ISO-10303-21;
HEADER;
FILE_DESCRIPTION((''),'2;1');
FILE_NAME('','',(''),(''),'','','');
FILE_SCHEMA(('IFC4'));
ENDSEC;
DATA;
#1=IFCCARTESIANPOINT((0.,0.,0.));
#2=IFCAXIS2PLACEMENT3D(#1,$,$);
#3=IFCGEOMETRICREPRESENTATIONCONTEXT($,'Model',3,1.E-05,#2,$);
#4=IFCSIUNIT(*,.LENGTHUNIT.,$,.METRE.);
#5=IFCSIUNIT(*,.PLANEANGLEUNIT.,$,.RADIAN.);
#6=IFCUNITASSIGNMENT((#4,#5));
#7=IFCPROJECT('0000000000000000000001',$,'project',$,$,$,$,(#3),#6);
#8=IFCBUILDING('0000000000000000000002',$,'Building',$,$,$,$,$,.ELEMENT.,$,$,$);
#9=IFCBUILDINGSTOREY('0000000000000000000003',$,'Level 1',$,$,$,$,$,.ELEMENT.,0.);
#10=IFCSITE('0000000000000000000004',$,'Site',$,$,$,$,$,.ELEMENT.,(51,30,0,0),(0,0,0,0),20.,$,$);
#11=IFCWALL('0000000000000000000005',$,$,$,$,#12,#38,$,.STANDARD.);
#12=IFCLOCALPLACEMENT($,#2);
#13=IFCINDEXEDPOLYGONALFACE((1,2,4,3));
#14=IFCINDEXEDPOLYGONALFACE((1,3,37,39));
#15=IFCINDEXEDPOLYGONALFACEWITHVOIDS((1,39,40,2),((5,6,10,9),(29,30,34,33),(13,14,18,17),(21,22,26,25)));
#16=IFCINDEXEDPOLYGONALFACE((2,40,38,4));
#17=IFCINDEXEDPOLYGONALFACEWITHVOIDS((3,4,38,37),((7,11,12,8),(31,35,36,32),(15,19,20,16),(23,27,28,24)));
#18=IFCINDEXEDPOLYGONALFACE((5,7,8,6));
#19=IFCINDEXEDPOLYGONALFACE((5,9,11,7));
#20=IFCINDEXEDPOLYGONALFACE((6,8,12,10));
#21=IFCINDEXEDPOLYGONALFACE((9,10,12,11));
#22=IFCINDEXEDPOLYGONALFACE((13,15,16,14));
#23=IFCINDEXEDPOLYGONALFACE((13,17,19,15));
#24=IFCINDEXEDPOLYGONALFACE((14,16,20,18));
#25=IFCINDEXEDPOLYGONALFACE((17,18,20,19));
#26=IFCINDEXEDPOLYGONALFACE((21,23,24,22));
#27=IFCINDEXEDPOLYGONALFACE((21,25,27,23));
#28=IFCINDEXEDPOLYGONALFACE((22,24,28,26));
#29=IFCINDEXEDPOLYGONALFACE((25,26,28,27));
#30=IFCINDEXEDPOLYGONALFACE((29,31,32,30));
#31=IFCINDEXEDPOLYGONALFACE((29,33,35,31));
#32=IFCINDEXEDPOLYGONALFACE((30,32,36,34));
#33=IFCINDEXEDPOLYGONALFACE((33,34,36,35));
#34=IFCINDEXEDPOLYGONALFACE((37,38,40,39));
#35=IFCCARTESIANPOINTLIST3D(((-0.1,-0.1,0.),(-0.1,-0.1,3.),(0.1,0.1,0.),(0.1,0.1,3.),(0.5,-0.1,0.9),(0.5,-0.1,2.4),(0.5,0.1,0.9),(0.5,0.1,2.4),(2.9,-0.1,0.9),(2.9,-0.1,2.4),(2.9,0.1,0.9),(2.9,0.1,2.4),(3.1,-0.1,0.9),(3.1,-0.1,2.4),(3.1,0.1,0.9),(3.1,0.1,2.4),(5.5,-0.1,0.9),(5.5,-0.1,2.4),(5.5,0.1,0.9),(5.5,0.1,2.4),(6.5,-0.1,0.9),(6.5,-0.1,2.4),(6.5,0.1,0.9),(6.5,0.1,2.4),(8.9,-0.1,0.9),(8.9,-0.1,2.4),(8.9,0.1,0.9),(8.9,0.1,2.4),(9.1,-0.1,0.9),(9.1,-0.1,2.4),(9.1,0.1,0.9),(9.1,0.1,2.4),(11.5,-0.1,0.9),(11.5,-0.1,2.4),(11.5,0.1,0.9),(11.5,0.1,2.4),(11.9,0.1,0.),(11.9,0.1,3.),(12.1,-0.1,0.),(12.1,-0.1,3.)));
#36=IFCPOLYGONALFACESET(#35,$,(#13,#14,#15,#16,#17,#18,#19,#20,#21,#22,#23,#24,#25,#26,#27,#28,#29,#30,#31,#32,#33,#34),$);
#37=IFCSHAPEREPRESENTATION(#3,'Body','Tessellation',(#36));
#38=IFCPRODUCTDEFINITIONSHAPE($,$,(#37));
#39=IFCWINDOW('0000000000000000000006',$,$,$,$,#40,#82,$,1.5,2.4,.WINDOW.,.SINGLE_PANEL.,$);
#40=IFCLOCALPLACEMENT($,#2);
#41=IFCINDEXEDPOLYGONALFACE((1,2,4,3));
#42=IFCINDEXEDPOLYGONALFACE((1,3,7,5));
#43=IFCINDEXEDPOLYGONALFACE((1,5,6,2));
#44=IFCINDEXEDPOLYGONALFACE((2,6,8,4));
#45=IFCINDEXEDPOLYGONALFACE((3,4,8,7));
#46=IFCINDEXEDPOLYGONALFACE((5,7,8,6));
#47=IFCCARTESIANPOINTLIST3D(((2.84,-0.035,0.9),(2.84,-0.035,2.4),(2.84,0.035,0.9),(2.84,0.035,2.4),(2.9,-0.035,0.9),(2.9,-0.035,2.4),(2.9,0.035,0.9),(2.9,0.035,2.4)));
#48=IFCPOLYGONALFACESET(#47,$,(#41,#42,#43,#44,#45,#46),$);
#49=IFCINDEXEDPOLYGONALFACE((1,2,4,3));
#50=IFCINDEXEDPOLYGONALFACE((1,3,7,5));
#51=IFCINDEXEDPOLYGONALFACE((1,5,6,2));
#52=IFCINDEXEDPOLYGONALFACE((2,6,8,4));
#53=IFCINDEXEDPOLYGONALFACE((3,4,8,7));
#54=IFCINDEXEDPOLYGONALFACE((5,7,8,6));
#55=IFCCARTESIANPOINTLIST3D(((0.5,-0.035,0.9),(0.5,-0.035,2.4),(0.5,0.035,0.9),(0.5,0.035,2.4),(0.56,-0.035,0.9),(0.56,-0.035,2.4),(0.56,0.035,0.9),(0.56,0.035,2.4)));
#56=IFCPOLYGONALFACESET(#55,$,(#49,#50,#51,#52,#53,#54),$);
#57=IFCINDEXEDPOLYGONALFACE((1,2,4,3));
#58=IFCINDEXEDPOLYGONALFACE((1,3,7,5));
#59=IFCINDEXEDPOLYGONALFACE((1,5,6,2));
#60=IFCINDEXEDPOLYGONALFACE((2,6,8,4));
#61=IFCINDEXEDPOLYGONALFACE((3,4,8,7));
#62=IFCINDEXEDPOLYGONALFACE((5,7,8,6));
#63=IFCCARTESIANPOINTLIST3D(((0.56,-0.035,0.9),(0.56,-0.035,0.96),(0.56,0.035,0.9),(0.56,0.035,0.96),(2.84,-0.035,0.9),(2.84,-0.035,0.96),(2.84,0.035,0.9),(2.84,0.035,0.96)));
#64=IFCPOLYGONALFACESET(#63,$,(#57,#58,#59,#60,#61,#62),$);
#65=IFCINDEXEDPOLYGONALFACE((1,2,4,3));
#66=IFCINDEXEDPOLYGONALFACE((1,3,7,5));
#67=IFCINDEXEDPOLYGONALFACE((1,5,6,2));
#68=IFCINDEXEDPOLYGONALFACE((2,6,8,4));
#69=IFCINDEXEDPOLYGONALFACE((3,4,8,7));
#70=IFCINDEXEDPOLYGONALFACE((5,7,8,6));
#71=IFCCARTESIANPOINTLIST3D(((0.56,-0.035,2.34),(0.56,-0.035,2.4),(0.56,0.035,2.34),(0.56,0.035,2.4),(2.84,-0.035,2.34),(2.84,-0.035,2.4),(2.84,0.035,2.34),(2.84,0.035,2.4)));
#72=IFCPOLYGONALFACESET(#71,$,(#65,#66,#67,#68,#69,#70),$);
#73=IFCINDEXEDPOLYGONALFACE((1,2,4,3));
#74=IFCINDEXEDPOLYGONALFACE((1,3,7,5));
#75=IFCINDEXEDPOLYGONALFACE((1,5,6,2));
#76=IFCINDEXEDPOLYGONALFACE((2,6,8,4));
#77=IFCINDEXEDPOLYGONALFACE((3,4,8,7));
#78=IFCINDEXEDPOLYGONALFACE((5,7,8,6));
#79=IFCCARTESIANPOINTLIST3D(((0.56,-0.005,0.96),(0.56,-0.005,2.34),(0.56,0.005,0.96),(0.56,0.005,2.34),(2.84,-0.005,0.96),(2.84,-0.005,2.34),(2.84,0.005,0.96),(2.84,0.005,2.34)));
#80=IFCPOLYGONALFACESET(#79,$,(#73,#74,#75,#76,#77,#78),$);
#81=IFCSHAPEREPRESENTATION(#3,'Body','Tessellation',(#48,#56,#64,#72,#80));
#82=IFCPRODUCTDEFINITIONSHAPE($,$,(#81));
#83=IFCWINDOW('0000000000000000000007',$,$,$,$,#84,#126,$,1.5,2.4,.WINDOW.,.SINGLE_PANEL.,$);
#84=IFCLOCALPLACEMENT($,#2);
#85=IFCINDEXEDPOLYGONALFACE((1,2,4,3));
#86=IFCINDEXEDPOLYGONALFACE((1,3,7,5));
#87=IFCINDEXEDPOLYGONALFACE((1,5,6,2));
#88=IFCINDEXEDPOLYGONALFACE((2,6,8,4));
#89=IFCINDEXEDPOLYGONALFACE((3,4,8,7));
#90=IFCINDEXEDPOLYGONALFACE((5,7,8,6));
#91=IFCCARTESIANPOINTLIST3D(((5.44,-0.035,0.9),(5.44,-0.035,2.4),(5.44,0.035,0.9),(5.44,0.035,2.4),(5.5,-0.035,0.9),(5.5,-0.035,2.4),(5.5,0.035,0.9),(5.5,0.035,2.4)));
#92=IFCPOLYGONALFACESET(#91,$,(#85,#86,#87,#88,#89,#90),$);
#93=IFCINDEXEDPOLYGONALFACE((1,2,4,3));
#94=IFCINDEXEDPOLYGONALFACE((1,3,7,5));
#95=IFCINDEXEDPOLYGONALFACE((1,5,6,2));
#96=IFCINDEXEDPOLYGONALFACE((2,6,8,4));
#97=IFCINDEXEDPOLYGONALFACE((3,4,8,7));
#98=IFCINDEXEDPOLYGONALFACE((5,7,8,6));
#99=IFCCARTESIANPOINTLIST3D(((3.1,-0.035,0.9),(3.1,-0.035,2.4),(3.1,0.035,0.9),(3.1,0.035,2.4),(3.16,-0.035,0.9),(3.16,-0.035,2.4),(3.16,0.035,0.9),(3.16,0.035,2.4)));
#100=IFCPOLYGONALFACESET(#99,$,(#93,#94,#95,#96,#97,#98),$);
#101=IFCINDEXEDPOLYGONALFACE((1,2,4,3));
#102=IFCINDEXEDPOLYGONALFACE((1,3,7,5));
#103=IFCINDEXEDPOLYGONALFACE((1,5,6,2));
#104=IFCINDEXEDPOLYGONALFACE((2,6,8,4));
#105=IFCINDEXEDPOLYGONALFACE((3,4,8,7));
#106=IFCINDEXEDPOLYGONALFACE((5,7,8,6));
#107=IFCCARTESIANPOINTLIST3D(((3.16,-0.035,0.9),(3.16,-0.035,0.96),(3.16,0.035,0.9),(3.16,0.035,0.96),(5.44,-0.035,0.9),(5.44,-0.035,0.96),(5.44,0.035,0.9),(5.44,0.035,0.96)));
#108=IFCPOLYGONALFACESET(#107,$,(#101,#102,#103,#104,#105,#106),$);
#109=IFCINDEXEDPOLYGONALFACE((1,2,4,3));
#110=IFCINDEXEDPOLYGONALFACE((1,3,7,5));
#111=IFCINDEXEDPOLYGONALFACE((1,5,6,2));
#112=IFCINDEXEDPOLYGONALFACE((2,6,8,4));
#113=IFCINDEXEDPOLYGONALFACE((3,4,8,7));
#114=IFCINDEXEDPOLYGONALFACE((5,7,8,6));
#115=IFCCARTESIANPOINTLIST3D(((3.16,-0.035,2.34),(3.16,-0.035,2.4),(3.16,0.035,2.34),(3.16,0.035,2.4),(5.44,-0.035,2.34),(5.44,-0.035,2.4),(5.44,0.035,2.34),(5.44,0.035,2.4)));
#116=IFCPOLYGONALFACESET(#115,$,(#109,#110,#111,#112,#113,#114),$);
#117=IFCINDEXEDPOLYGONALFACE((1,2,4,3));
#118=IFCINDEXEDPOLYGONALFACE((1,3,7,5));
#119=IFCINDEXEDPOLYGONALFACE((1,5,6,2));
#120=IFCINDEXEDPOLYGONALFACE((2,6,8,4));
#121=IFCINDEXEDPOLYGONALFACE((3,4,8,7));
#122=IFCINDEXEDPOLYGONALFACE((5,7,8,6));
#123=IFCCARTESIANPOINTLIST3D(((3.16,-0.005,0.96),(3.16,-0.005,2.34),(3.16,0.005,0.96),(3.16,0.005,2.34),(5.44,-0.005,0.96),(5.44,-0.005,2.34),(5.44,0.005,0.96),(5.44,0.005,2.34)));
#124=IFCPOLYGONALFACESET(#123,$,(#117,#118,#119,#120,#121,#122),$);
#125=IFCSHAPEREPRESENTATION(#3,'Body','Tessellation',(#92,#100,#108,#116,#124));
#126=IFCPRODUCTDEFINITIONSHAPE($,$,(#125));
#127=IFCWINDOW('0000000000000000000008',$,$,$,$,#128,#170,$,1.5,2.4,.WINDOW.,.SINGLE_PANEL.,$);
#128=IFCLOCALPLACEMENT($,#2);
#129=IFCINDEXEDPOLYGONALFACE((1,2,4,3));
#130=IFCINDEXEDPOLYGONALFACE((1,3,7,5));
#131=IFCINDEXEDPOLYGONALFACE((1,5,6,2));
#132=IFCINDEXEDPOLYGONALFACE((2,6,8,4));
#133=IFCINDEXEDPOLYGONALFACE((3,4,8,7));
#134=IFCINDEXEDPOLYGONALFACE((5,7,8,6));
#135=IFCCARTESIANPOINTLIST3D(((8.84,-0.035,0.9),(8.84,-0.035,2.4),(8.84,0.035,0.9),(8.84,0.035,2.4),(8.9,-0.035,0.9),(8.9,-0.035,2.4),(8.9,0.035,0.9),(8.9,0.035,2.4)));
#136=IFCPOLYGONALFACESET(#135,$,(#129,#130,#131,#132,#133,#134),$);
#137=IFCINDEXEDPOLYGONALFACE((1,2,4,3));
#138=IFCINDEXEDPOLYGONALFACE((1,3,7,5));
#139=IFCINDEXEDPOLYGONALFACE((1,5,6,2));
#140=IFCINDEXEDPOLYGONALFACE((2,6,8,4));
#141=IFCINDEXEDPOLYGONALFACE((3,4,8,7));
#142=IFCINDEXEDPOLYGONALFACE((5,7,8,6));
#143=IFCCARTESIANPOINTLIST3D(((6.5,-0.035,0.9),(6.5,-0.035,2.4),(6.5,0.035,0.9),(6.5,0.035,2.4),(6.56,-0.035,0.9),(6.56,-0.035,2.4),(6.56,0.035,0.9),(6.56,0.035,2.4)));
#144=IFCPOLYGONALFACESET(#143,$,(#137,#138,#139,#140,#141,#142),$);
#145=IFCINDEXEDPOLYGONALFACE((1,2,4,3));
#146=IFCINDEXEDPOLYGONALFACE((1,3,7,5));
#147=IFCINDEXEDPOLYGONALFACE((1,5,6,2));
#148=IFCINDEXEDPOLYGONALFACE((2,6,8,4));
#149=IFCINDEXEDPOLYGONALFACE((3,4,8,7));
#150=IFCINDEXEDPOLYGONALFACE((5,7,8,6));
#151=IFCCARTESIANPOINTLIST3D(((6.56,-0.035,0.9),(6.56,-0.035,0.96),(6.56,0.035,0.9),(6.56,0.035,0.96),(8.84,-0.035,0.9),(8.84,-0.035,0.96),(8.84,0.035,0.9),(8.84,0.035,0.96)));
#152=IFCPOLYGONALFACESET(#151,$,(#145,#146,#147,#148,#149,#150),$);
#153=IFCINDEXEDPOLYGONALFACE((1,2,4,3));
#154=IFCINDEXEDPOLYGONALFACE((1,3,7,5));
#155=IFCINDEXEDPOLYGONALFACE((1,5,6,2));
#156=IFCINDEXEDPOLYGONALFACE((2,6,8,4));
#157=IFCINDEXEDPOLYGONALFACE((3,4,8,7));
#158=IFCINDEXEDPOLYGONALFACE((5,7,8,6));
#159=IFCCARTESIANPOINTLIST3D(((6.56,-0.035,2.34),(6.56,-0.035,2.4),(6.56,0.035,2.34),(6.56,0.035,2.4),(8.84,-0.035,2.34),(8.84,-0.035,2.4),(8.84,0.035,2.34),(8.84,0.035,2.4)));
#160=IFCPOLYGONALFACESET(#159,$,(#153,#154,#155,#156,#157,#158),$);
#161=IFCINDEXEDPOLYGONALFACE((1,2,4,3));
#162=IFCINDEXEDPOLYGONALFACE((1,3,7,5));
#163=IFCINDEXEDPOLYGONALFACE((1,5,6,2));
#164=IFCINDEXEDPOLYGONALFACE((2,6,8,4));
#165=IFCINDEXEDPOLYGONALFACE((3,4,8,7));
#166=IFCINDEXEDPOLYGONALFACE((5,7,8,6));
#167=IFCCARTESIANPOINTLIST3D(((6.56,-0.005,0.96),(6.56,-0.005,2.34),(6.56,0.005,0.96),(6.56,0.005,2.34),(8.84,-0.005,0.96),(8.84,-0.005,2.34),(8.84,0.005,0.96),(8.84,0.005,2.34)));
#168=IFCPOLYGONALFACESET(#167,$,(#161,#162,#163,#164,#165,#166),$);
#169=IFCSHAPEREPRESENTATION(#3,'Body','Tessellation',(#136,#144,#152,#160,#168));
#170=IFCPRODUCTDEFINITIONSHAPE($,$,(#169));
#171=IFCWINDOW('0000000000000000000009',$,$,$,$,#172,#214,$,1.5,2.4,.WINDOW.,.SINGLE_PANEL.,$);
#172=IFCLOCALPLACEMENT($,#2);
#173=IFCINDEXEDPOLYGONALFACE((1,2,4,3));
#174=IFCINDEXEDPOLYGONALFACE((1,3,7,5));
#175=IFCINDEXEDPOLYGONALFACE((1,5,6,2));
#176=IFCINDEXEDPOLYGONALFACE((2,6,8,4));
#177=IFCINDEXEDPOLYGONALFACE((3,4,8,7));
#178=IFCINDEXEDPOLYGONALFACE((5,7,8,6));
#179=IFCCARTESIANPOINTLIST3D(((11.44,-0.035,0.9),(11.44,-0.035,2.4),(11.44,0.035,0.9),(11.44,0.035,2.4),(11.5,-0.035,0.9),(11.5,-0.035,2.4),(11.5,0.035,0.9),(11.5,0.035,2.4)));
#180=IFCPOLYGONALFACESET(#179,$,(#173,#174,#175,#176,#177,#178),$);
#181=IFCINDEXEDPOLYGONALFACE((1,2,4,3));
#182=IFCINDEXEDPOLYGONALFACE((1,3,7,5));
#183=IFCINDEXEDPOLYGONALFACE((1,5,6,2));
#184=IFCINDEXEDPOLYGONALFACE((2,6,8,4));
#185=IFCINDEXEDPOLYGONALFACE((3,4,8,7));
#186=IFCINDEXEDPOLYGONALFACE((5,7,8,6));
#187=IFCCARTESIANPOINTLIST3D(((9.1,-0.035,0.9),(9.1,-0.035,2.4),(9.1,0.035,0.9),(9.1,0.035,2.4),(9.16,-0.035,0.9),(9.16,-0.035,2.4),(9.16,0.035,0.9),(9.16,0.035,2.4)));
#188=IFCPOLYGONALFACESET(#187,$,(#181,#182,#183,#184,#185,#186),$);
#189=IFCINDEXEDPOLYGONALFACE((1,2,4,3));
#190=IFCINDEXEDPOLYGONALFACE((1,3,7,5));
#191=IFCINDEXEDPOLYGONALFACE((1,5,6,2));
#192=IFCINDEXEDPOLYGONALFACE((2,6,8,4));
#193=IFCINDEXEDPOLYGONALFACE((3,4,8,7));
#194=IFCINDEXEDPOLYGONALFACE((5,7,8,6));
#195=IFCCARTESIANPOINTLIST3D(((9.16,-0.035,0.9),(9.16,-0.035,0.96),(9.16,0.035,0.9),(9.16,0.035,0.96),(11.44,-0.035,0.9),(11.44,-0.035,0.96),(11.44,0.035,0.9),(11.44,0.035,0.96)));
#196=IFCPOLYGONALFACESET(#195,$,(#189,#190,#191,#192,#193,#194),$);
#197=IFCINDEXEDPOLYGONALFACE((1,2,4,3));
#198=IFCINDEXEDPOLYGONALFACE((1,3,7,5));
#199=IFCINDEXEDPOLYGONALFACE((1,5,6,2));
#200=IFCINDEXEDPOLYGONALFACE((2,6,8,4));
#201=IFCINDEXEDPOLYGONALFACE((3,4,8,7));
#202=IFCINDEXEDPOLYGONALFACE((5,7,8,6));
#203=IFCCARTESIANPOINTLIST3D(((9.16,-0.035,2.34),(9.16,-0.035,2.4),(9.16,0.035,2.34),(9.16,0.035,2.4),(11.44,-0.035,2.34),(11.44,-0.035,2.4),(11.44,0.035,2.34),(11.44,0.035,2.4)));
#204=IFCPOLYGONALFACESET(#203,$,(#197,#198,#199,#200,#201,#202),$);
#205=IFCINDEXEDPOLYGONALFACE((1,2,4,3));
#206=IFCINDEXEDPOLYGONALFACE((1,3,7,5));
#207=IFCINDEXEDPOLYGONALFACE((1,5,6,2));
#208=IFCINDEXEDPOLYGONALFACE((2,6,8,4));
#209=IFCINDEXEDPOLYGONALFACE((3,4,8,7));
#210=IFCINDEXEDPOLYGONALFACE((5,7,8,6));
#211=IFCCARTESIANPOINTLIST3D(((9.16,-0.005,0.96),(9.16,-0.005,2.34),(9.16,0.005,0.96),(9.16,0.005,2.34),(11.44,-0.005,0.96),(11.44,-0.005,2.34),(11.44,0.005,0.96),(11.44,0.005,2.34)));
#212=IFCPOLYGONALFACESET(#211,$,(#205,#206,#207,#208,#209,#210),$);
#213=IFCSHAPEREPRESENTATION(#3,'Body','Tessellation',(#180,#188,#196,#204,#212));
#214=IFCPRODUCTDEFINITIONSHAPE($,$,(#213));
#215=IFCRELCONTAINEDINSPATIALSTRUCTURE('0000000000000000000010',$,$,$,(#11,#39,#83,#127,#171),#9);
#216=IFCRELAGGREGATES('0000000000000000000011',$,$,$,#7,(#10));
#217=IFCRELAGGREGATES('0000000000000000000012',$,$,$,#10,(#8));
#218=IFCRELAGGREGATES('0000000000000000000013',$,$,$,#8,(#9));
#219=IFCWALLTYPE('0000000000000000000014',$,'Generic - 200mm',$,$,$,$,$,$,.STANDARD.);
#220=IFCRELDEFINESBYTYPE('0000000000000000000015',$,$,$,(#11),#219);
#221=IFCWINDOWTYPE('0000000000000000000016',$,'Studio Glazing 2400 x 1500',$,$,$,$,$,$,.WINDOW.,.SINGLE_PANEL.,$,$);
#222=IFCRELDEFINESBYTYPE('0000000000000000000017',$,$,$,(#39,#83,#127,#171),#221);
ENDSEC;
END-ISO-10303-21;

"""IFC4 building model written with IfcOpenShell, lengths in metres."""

from ifc_helpers import new_model, si_unit, frame, frame_2d, origin, origin_with_axes, origin_2d, place, context, project, spatial, polyline, rectangle, outline, extrude, type_object, element, fill, save


model = new_model("IFC4")

# Units and contexts
model_context = context("Model", 3, precision=1e-05, world=origin())
ifc_project = project(units=[si_unit("LENGTHUNIT", "METRE"), si_unit("PLANEANGLEUNIT", "RADIAN")], contexts=[model_context])

# Site, building, storey
site = spatial("IfcSite", under=ifc_project, Name="Site", CompositionType="ELEMENT", RefLatitude=(51, 30, 0, 0), RefLongitude=(0, 0, 0, 0), RefElevation=20.0)
building = spatial("IfcBuilding", under=site, Name="Building", CompositionType="ELEMENT")
storey = spatial("IfcBuildingStorey", under=building, Name="Level 1", CompositionType="ELEMENT", Elevation=0.0)

# Wall, openings, windows
wall_type = type_object("IfcWallType", Name="Generic - 200mm", PredefinedType="STANDARD")
wall_1_placement = place(None, frame((12.0, 0.0, 0.0), z_axis=(0.0, 0.0, 1.0), x_axis=(-1.0, 0.0, 0.0)))
wall_1 = element("IfcWall", 1, at=wall_1_placement, inside=storey, type_object=wall_type, PredefinedType="STANDARD", context=model_context, shape_type="SweptSolid", body=[
    extrude(outline(polyline([(0.1, -0.1), (11.9, -0.1), (12.1, 0.1), (-0.1, 0.1), (0.1, -0.1)])), origin(), (0.0, 0.0, 1.0), 3.0),
])
opening_1_placement = place(wall_1_placement, frame((10.3, 0.0, 0.9), z_axis=(0.0, 0.0, 1.0), x_axis=(1.0, 0.0, 0.0)))
opening_1 = element("IfcOpeningElement", 2, at=opening_1_placement, cuts=wall_1, PredefinedType="OPENING", context=model_context, shape_type="SweptSolid", body=[
    extrude(rectangle(XDim=2.4, YDim=0.202, at=origin_2d()), origin(), (0.0, 0.0, 1.0), 1.5),
])
opening_2_placement = place(wall_1_placement, frame((7.7, 0.0, 0.9), z_axis=(0.0, 0.0, 1.0), x_axis=(1.0, 0.0, 0.0)))
opening_2 = element("IfcOpeningElement", 3, at=opening_2_placement, cuts=wall_1, PredefinedType="OPENING", context=model_context, shape_type="SweptSolid", body=[
    extrude(rectangle(XDim=2.4, YDim=0.202, at=origin_2d()), origin(), (0.0, 0.0, 1.0), 1.5),
])
opening_3_placement = place(wall_1_placement, frame((4.3, 0.0, 0.9), z_axis=(0.0, 0.0, 1.0), x_axis=(1.0, 0.0, 0.0)))
opening_3 = element("IfcOpeningElement", 4, at=opening_3_placement, cuts=wall_1, PredefinedType="OPENING", context=model_context, shape_type="SweptSolid", body=[
    extrude(rectangle(XDim=2.4, YDim=0.202, at=origin_2d()), origin(), (0.0, 0.0, 1.0), 1.5),
])
opening_4_placement = place(wall_1_placement, frame((1.7, 0.0, 0.9), z_axis=(0.0, 0.0, 1.0), x_axis=(1.0, 0.0, 0.0)))
opening_4 = element("IfcOpeningElement", 5, at=opening_4_placement, cuts=wall_1, PredefinedType="OPENING", context=model_context, shape_type="SweptSolid", body=[
    extrude(rectangle(XDim=2.4, YDim=0.202, at=origin_2d()), origin(), (0.0, 0.0, 1.0), 1.5),
])
window_type = type_object("IfcWindowType", Name="Studio Glazing 2400 x 1500", PartitioningType="SINGLE_PANEL", PredefinedType="WINDOW")
window_1_placement = place(opening_1_placement, origin_with_axes())
window_1 = element("IfcWindow", 6, at=window_1_placement, inside=storey, type_object=window_type, OverallHeight=1.5, OverallWidth=2.4, PartitioningType="SINGLE_PANEL", PredefinedType="WINDOW", context=model_context, shape_type="SweptSolid", body=[
    extrude(rectangle(XDim=0.06, YDim=0.07, at=frame_2d((-1.17, 0.0))), origin(), (0.0, 0.0, 1.0), 1.5),
    extrude(rectangle(XDim=0.06, YDim=0.07, at=frame_2d((1.17, 0.0))), origin(), (0.0, 0.0, 1.0), 1.5),
    extrude(rectangle(XDim=2.28, YDim=0.07, at=origin_2d()), origin(), (0.0, 0.0, 1.0), 0.06),
    extrude(rectangle(XDim=2.28, YDim=0.07, at=origin_2d()), frame((0.0, 0.0, 1.44)), (0.0, 0.0, 1.0), 0.06),
    extrude(rectangle(XDim=2.28, YDim=0.01, at=origin_2d()), frame((0.0, 0.0, 0.06)), (0.0, 0.0, 1.0), 1.38),
])
fill(opening_1, window_1)
window_2_placement = place(opening_2_placement, origin_with_axes())
window_2 = element("IfcWindow", 7, at=window_2_placement, inside=storey, type_object=window_type, OverallHeight=1.5, OverallWidth=2.4, PartitioningType="SINGLE_PANEL", PredefinedType="WINDOW", context=model_context, shape_type="SweptSolid", body=[
    extrude(rectangle(XDim=0.06, YDim=0.07, at=frame_2d((-1.17, 0.0))), origin(), (0.0, 0.0, 1.0), 1.5),
    extrude(rectangle(XDim=0.06, YDim=0.07, at=frame_2d((1.17, 0.0))), origin(), (0.0, 0.0, 1.0), 1.5),
    extrude(rectangle(XDim=2.28, YDim=0.07, at=origin_2d()), origin(), (0.0, 0.0, 1.0), 0.06),
    extrude(rectangle(XDim=2.28, YDim=0.07, at=origin_2d()), frame((0.0, 0.0, 1.44)), (0.0, 0.0, 1.0), 0.06),
    extrude(rectangle(XDim=2.28, YDim=0.01, at=origin_2d()), frame((0.0, 0.0, 0.06)), (0.0, 0.0, 1.0), 1.38),
])
fill(opening_2, window_2)
window_3_placement = place(opening_3_placement, origin_with_axes())
window_3 = element("IfcWindow", 8, at=window_3_placement, inside=storey, type_object=window_type, OverallHeight=1.5, OverallWidth=2.4, PartitioningType="SINGLE_PANEL", PredefinedType="WINDOW", context=model_context, shape_type="SweptSolid", body=[
    extrude(rectangle(XDim=0.06, YDim=0.07, at=frame_2d((-1.17, 0.0))), origin(), (0.0, 0.0, 1.0), 1.5),
    extrude(rectangle(XDim=0.06, YDim=0.07, at=frame_2d((1.17, 0.0))), origin(), (0.0, 0.0, 1.0), 1.5),
    extrude(rectangle(XDim=2.28, YDim=0.07, at=origin_2d()), origin(), (0.0, 0.0, 1.0), 0.06),
    extrude(rectangle(XDim=2.28, YDim=0.07, at=origin_2d()), frame((0.0, 0.0, 1.44)), (0.0, 0.0, 1.0), 0.06),
    extrude(rectangle(XDim=2.28, YDim=0.01, at=origin_2d()), frame((0.0, 0.0, 0.06)), (0.0, 0.0, 1.0), 1.38),
])
fill(opening_3, window_3)
window_4_placement = place(opening_4_placement, origin_with_axes())
window_4 = element("IfcWindow", 9, at=window_4_placement, inside=storey, type_object=window_type, OverallHeight=1.5, OverallWidth=2.4, PartitioningType="SINGLE_PANEL", PredefinedType="WINDOW", context=model_context, shape_type="SweptSolid", body=[
    extrude(rectangle(XDim=0.06, YDim=0.07, at=frame_2d((-1.17, 0.0))), origin(), (0.0, 0.0, 1.0), 1.5),
    extrude(rectangle(XDim=0.06, YDim=0.07, at=frame_2d((1.17, 0.0))), origin(), (0.0, 0.0, 1.0), 1.5),
    extrude(rectangle(XDim=2.28, YDim=0.07, at=origin_2d()), origin(), (0.0, 0.0, 1.0), 0.06),
    extrude(rectangle(XDim=2.28, YDim=0.07, at=origin_2d()), frame((0.0, 0.0, 1.44)), (0.0, 0.0, 1.0), 0.06),
    extrude(rectangle(XDim=2.28, YDim=0.01, at=origin_2d()), frame((0.0, 0.0, 0.06)), (0.0, 0.0, 1.0), 1.38),
])
fill(opening_4, window_4)

save(model, "model.ifc")
